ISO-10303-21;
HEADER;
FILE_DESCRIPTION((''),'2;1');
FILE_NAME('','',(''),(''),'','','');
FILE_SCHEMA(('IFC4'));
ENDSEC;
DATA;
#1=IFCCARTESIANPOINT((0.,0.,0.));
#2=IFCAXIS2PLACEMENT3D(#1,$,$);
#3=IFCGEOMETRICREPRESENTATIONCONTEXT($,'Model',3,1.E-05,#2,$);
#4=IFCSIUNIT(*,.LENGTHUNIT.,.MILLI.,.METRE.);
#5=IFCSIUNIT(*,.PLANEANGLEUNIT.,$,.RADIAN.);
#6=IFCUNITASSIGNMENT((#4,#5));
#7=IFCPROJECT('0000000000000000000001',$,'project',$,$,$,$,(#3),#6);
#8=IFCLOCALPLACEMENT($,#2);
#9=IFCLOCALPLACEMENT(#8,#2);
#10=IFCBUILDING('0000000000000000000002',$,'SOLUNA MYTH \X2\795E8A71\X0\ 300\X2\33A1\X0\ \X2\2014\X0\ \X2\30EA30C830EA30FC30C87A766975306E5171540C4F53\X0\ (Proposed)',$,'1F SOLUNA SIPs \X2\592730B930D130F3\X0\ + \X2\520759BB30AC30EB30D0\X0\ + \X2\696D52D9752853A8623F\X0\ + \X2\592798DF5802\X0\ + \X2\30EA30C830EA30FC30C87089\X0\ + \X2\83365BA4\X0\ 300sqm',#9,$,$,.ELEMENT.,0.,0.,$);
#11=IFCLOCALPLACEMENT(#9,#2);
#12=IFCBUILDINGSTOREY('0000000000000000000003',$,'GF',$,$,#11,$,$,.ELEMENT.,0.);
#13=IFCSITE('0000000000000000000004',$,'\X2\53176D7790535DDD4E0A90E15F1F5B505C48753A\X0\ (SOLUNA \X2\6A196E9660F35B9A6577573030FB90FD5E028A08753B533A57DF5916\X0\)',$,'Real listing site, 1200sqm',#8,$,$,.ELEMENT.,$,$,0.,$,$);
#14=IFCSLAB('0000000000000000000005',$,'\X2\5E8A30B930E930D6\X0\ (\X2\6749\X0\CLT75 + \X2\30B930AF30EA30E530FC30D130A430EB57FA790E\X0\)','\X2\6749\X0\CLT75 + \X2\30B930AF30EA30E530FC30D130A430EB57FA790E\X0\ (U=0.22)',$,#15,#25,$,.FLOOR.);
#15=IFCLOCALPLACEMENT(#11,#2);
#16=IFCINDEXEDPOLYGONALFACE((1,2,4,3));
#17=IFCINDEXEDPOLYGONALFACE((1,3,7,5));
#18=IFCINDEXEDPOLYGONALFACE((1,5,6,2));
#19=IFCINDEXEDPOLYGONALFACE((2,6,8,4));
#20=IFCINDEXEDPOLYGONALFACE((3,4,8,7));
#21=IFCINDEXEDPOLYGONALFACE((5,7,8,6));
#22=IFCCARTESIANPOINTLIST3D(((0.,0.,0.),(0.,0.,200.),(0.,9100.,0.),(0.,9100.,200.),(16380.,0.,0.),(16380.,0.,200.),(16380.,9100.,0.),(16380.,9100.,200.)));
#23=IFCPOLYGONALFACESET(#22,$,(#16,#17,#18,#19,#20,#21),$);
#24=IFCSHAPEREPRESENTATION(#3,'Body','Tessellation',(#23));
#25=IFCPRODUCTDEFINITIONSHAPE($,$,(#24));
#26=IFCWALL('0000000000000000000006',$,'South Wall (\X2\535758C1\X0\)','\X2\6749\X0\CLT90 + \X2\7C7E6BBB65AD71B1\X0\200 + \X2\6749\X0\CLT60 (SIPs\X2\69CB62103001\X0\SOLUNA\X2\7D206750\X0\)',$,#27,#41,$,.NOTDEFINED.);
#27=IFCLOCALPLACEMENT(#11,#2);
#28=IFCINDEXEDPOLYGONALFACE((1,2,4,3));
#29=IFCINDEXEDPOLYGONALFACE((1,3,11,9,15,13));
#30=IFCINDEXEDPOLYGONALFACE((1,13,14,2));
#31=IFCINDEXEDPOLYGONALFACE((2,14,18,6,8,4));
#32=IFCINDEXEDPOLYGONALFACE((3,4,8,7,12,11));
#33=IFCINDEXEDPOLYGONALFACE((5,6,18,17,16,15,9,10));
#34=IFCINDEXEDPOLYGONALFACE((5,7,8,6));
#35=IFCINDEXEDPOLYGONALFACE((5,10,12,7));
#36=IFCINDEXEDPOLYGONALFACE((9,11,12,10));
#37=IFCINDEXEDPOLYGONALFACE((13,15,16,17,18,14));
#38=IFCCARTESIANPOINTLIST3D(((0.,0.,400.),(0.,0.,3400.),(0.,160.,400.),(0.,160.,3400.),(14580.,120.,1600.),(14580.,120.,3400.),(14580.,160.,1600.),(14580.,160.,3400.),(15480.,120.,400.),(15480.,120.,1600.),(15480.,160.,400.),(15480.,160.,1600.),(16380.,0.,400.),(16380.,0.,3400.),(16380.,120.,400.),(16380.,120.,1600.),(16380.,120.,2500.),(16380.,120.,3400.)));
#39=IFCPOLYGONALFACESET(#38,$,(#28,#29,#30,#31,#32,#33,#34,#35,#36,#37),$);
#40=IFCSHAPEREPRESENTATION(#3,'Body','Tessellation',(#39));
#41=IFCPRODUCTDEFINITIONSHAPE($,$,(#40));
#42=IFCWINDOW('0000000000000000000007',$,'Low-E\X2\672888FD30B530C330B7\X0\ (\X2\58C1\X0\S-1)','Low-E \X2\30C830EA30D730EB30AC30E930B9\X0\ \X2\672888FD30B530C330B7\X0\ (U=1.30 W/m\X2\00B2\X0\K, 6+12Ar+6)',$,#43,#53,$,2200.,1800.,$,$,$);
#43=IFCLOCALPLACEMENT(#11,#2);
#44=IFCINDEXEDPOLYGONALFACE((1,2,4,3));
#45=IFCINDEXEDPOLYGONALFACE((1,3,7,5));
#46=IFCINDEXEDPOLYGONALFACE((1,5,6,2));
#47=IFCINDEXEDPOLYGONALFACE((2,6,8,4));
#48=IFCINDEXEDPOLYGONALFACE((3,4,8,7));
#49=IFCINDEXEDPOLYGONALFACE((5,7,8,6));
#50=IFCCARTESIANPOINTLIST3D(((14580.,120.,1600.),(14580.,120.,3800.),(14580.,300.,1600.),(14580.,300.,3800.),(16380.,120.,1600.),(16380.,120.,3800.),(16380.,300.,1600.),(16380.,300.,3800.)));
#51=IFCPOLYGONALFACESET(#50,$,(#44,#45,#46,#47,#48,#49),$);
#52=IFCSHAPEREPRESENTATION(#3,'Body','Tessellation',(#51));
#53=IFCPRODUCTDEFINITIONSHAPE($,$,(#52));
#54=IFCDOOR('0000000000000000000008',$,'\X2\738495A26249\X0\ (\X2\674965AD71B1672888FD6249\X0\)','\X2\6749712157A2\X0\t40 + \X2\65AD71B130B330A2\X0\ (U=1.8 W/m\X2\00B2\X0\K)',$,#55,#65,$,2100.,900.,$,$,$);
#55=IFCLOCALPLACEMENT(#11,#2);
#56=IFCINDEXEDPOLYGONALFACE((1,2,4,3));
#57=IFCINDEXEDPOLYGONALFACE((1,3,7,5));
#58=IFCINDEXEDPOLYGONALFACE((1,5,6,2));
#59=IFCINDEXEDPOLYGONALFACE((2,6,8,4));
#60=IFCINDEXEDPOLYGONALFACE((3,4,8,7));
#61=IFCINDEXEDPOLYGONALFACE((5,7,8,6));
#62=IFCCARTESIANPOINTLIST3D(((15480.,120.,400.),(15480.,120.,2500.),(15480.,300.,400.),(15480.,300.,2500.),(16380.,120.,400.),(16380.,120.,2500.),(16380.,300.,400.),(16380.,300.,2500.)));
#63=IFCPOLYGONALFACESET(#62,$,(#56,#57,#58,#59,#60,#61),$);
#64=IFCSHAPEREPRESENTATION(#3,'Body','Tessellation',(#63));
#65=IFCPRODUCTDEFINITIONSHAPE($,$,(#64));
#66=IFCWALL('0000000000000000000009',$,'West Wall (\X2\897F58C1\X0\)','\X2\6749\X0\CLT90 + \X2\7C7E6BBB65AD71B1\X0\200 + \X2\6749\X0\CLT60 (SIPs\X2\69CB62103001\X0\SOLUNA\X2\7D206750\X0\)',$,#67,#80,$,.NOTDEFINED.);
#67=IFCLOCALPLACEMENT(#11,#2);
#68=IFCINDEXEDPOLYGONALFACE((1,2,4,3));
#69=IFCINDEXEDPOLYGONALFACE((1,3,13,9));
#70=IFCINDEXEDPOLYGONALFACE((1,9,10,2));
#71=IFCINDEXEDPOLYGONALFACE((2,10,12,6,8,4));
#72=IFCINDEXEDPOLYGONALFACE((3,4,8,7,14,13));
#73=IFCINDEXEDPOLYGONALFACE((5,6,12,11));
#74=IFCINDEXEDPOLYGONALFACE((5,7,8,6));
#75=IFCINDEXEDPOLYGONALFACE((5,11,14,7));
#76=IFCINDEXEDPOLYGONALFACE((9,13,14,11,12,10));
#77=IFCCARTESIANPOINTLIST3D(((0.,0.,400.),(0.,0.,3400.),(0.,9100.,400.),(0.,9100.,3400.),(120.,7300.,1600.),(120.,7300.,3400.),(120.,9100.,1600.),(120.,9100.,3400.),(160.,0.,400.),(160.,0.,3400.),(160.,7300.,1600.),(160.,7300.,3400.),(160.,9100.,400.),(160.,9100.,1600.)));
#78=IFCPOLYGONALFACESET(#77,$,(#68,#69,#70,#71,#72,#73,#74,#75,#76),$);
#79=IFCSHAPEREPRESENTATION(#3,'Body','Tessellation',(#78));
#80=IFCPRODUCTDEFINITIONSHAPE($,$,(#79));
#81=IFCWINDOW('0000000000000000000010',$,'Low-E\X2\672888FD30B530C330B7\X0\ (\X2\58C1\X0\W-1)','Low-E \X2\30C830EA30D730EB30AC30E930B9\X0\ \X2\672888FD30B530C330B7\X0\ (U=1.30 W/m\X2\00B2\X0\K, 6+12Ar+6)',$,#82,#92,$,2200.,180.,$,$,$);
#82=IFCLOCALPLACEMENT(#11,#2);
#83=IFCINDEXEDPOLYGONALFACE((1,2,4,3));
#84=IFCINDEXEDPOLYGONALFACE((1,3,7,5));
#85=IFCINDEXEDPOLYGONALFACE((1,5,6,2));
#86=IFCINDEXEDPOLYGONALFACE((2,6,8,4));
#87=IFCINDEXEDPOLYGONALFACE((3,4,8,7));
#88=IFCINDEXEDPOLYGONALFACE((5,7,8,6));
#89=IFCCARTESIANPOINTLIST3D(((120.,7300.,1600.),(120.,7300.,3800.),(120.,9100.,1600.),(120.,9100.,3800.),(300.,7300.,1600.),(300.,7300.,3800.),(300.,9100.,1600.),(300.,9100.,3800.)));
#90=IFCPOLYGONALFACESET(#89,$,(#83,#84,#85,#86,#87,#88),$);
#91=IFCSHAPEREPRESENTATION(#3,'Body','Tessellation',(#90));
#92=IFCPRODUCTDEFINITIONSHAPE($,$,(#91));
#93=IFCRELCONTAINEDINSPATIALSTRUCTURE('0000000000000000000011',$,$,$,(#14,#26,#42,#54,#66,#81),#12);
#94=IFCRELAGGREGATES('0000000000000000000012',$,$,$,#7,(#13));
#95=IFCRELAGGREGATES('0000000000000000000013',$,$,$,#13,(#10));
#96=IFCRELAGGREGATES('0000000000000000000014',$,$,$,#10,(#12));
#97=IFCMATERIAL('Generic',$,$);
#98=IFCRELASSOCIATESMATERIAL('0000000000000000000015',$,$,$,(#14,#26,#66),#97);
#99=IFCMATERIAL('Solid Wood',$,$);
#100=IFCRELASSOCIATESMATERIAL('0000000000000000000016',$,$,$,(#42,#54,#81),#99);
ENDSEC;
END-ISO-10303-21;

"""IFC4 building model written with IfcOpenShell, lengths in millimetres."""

from ifc_helpers import new_model, si_unit, frame, frame_2d, origin, place, context, project, spatial, rectangle, extrude, material, element, fill, save


model = new_model("IFC4")

# Units and contexts
model_context = context("Model", 3, precision=1e-05, world=origin())
ifc_project = project(units=[si_unit("LENGTHUNIT", "METRE", prefix="MILLI"), si_unit("PLANEANGLEUNIT", "RADIAN")], contexts=[model_context])

# Site, building, storey
site_placement = place(None, origin())
site = spatial("IfcSite", under=ifc_project, at=site_placement, Name="北海道川上郡弟子屈町 (SOLUNA 標準想定敷地・都市計画区域外)", ObjectType="Real listing site, 1200sqm", CompositionType="ELEMENT", RefElevation=0.0)
building_placement = place(site_placement, origin())
building = spatial("IfcBuilding", under=site, at=building_placement, Name="SOLUNA MYTH 神話 300㎡ — リトリート究極の共同体 (Proposed)", ObjectType="1F SOLUNA SIPs 大スパン + 切妻ガルバ + 業務用厨房 + 大食堂 + リトリート炉 + 茶室 300sqm", CompositionType="ELEMENT", ElevationOfRefHeight=0.0, ElevationOfTerrain=0.0)
storey_placement = place(building_placement, origin())
storey = spatial("IfcBuildingStorey", under=building, at=storey_placement, Name="GF", CompositionType="ELEMENT", Elevation=0.0)

# Slab
ifc_material_1 = material(Name="Generic")
slab_placement = place(storey_placement, origin())
element("IfcSlab", 1, at=slab_placement, inside=storey, material=ifc_material_1, Name="床スラブ (杉CLT75 + スクリューパイル基礎)", Description="杉CLT75 + スクリューパイル基礎 (U=0.22)", PredefinedType="FLOOR", context=model_context, shape_type="SweptSolid", body=[
    extrude(rectangle(XDim=16380.0, YDim=9100.0, at=frame_2d((8190.0, 4550.0))), origin(), (0.0, 0.0, 1.0), 200.0),
])

# Wall, openings, window, door
wall_1_placement = place(storey_placement, frame((0.0, 0.0, 200.0)))
wall_1 = element("IfcWall", 2, at=wall_1_placement, inside=storey, material=ifc_material_1, Name="South Wall (南壁)", Description="杉CLT90 + 籾殻断熱200 + 杉CLT60 (SIPs構成、SOLUNA素材)", PredefinedType="NOTDEFINED", context=model_context, shape_type="SweptSolid", body=[
    extrude(rectangle(XDim=16380.0, YDim=160.0, at=frame_2d((8190.0, 80.0))), frame((0.0, 0.0, 200.0)), (0.0, 0.0, 1.0), 3000.0),
])
opening_1_placement = place(storey_placement, frame((7290.0, 60.0, 800.0)))
opening_1 = element("IfcOpeningElement", 3, at=opening_1_placement, cuts=wall_1, PredefinedType="NOTDEFINED", context=model_context, shape_type="SweptSolid", body=[
    extrude(rectangle(XDim=1800.0, YDim=180.0, at=frame_2d((900.0, 90.0))), frame((7290.0, 60.0, 800.0)), (0.0, 0.0, 1.0), 2200.0),
])
opening_2_placement = place(storey_placement, frame((7740.0, 60.0, 200.0)))
opening_2 = element("IfcOpeningElement", 4, at=opening_2_placement, cuts=wall_1, PredefinedType="NOTDEFINED", context=model_context, shape_type="SweptSolid", body=[
    extrude(rectangle(XDim=900.0, YDim=180.0, at=frame_2d((450.0, 90.0))), frame((7740.0, 60.0, 200.0)), (0.0, 0.0, 1.0), 2100.0),
])
ifc_material_2 = material(Name="Solid Wood")
window_1_placement = place(storey_placement, frame((7290.0, 60.0, 800.0)))
window_1 = element("IfcWindow", 5, at=window_1_placement, inside=storey, material=ifc_material_2, Name="Low-E木製サッシ (壁S-1)", Description="Low-E トリプルガラス 木製サッシ (U=1.30 W/m²K, 6+12Ar+6)", OverallHeight=2200.0, OverallWidth=1800.0, context=model_context, shape_type="SweptSolid", body=[
    extrude(rectangle(XDim=1800.0, YDim=180.0, at=frame_2d((900.0, 90.0))), frame((7290.0, 60.0, 800.0)), (0.0, 0.0, 1.0), 2200.0),
])
fill(opening_1, window_1)
door_placement = place(storey_placement, frame((7740.0, 60.0, 200.0)))
door = element("IfcDoor", 6, at=door_placement, inside=storey, material=ifc_material_2, Name="玄関扉 (杉断熱木製扉)", Description="杉無垢t40 + 断熱コア (U=1.8 W/m²K)", OverallHeight=2100.0, OverallWidth=900.0, context=model_context, shape_type="SweptSolid", body=[
    extrude(rectangle(XDim=900.0, YDim=180.0, at=frame_2d((450.0, 90.0))), frame((7740.0, 60.0, 200.0)), (0.0, 0.0, 1.0), 2100.0),
])
fill(opening_2, door)

# Wall, opening, window
wall_2_placement = place(storey_placement, frame((0.0, 0.0, 200.0)))
wall_2 = element("IfcWall", 7, at=wall_2_placement, inside=storey, material=ifc_material_1, Name="West Wall (西壁)", Description="杉CLT90 + 籾殻断熱200 + 杉CLT60 (SIPs構成、SOLUNA素材)", PredefinedType="NOTDEFINED", context=model_context, shape_type="SweptSolid", body=[
    extrude(rectangle(XDim=160.0, YDim=9100.0, at=frame_2d((80.0, 4550.0))), frame((0.0, 0.0, 200.0)), (0.0, 0.0, 1.0), 3000.0),
])
opening_3_placement = place(storey_placement, frame((60.0, 3650.0, 800.0)))
opening_3 = element("IfcOpeningElement", 8, at=opening_3_placement, cuts=wall_2, PredefinedType="NOTDEFINED", context=model_context, shape_type="SweptSolid", body=[
    extrude(rectangle(XDim=180.0, YDim=1800.0, at=frame_2d((90.0, 900.0))), frame((60.0, 3650.0, 800.0)), (0.0, 0.0, 1.0), 2200.0),
])
window_2_placement = place(storey_placement, frame((60.0, 3650.0, 800.0)))
window_2 = element("IfcWindow", 9, at=window_2_placement, inside=storey, material=ifc_material_2, Name="Low-E木製サッシ (壁W-1)", Description="Low-E トリプルガラス 木製サッシ (U=1.30 W/m²K, 6+12Ar+6)", OverallHeight=2200.0, OverallWidth=180.0, context=model_context, shape_type="SweptSolid", body=[
    extrude(rectangle(XDim=180.0, YDim=1800.0, at=frame_2d((90.0, 900.0))), frame((60.0, 3650.0, 800.0)), (0.0, 0.0, 1.0), 2200.0),
])
fill(opening_3, window_2)

save(model, "model.ifc")
